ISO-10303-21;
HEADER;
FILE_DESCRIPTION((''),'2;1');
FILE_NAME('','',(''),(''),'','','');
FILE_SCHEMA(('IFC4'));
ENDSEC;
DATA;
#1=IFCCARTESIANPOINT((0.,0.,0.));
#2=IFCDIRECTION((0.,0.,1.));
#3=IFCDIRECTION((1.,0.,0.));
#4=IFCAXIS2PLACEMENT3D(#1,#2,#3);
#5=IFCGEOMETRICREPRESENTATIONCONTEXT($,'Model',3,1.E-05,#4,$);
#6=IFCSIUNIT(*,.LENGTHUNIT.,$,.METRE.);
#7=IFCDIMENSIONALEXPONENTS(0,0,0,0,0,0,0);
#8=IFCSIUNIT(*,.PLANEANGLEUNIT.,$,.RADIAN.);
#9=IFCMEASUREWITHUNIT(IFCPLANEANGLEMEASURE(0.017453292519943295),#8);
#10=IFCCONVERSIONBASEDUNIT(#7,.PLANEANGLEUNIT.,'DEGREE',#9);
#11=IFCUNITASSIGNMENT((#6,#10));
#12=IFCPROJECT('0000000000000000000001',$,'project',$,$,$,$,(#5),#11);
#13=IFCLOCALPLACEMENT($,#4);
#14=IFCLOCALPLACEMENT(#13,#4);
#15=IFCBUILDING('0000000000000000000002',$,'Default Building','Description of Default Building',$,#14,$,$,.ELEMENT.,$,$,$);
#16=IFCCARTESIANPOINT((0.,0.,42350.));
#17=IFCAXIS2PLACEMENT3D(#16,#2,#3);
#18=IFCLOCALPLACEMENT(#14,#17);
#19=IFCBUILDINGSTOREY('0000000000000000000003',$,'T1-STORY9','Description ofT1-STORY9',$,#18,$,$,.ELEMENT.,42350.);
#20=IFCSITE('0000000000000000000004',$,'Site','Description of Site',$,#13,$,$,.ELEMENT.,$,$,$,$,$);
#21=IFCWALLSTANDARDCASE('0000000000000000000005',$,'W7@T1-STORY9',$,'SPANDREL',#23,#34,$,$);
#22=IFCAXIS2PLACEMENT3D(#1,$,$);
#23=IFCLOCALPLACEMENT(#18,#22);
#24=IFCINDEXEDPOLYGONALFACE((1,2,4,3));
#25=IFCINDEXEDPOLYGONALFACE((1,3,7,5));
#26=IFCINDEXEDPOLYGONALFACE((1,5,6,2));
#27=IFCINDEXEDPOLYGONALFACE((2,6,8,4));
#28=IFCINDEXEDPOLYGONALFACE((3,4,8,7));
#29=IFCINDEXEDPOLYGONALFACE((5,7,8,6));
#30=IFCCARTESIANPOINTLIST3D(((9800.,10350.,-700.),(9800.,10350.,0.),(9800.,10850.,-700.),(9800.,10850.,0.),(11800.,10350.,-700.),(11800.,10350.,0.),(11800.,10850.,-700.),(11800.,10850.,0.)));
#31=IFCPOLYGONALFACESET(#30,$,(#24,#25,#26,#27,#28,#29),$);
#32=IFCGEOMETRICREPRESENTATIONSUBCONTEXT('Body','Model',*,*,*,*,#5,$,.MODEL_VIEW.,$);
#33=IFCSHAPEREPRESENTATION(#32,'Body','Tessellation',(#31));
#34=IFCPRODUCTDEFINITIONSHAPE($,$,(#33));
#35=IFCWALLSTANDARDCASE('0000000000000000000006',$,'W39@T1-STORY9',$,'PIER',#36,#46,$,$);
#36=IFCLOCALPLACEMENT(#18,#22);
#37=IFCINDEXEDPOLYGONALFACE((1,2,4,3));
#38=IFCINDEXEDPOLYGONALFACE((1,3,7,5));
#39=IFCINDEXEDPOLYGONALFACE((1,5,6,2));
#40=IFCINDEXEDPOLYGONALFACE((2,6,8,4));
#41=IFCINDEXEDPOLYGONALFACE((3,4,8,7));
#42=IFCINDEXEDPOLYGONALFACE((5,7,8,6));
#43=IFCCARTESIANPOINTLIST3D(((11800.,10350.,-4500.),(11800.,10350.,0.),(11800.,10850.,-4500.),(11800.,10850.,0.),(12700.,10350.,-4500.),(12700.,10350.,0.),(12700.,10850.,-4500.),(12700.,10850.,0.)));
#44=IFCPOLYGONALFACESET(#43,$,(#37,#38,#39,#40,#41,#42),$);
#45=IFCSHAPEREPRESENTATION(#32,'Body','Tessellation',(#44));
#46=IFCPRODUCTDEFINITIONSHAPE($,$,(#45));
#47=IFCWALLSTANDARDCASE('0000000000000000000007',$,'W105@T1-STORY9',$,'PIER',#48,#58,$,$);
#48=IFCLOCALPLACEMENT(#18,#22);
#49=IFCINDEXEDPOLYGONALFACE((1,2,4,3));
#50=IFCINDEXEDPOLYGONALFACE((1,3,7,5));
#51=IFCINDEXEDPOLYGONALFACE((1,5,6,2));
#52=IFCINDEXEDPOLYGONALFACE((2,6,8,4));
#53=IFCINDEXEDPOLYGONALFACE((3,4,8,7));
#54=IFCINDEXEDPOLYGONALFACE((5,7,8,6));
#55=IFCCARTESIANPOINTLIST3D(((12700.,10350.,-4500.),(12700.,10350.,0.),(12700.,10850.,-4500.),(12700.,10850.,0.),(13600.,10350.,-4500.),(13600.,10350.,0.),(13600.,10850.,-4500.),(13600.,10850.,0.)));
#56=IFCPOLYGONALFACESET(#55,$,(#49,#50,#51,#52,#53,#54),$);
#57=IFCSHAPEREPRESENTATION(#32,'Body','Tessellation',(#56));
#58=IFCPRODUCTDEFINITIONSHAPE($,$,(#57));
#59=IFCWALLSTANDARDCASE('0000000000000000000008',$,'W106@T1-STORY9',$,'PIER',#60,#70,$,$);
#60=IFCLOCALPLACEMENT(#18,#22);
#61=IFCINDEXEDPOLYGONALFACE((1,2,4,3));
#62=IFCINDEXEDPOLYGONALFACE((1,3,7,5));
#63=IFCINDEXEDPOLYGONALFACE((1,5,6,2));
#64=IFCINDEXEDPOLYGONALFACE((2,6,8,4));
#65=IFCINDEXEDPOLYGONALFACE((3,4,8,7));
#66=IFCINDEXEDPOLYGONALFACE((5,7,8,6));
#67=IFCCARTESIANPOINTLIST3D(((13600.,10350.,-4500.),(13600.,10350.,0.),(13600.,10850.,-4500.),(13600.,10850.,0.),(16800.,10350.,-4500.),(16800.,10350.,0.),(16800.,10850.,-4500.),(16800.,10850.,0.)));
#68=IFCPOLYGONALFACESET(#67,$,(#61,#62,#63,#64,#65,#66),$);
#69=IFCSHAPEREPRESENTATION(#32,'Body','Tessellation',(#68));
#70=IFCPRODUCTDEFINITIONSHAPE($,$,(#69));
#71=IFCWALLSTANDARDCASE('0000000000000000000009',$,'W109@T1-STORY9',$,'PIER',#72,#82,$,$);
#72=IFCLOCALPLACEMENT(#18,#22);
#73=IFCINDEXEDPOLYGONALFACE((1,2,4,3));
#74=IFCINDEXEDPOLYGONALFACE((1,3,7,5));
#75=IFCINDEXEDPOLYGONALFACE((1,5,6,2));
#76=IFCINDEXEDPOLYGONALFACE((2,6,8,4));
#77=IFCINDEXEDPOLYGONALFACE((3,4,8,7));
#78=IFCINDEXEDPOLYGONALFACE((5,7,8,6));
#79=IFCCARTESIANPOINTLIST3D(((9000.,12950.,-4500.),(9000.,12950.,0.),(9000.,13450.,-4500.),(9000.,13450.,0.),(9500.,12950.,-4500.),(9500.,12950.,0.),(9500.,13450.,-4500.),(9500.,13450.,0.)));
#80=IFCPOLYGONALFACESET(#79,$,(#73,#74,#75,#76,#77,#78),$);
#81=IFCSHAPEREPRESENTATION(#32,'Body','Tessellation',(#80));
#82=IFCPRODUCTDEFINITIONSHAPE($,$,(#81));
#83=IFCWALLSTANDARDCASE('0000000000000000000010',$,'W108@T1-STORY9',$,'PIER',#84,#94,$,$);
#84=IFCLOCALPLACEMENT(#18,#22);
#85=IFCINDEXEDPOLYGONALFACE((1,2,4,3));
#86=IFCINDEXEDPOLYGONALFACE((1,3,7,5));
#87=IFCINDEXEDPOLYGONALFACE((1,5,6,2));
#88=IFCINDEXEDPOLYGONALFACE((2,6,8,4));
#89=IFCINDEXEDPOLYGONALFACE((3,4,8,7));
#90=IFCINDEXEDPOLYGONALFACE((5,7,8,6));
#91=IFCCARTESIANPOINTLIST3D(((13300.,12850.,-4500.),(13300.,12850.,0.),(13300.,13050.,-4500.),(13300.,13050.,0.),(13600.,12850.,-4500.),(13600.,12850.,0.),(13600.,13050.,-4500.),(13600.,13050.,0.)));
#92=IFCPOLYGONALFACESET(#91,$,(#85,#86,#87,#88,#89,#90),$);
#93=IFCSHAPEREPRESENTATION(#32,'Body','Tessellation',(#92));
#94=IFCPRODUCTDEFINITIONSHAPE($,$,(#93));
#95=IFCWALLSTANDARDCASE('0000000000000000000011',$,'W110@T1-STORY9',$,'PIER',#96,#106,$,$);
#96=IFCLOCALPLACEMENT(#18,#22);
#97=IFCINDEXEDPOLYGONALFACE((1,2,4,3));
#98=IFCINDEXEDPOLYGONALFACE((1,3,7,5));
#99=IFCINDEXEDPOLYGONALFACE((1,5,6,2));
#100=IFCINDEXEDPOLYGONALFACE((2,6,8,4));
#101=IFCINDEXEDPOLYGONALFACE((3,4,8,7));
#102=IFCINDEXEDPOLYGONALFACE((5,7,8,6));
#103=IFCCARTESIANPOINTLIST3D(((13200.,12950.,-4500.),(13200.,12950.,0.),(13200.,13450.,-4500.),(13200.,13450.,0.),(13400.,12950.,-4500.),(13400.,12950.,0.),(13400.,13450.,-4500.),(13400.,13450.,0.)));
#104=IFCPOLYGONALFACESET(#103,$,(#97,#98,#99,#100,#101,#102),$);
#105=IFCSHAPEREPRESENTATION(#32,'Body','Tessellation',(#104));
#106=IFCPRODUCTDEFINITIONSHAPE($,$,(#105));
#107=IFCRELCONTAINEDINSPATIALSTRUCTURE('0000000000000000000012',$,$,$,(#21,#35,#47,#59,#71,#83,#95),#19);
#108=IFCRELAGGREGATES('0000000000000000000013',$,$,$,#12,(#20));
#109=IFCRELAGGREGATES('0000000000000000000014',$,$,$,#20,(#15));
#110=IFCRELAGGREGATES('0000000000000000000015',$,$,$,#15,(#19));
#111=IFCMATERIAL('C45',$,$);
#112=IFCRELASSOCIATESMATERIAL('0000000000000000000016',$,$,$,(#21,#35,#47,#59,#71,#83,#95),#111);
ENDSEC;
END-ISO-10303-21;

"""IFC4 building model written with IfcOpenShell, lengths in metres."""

from ifc_helpers import new_model, entity, si_unit, converted_unit, frame, origin_with_axes, place, context, subcontext, project, spatial, indexed_curve, outline, extrude, material, element, save


model = new_model("IFC4")

# Units and contexts
model_context = context("Model", 3, precision=1e-05, world=origin_with_axes())
body_context = subcontext(model_context, "Body", "Model", "MODEL_VIEW")
ifc_project = project(units=[si_unit("LENGTHUNIT", "METRE"), converted_unit("PLANEANGLEUNIT", "DEGREE", entity("IfcPlaneAngleMeasure", 0.017453292519943295), si_unit("PLANEANGLEUNIT", "RADIAN"), dimensions=[0, 0, 0, 0, 0, 0, 0])], contexts=[model_context])

# Site, building, storey
site_placement = place(None, origin_with_axes())
site = spatial("IfcSite", under=ifc_project, at=site_placement, Name="Site", Description="Description of Site", CompositionType="ELEMENT")
building_placement = place(site_placement, origin_with_axes())
building = spatial("IfcBuilding", under=site, at=building_placement, Name="Default Building", Description="Description of Default Building", CompositionType="ELEMENT")
storey_placement = place(building_placement, frame((0.0, 0.0, 42350.0), z_axis=(0.0, 0.0, 1.0), x_axis=(1.0, 0.0, 0.0)))
storey = spatial("IfcBuildingStorey", under=building, at=storey_placement, Name="T1-STORY9", Description="Description ofT1-STORY9", CompositionType="ELEMENT", Elevation=42350.0)

# Shared definitions
ifc_material_1 = material(Name="C45")

# Walls
wall_1_placement = place(storey_placement, frame((9800.0, 10600.0, -700.0), z_axis=(0.0, 0.0, 1.0), x_axis=(1.0, 0.0, 0.0)))
element("IfcWallStandardCase", 1, at=wall_1_placement, inside=storey, material=ifc_material_1, Name="W7@T1-STORY9", ObjectType="SPANDREL", context=body_context, shape_type="SweptSolid", body=[
    extrude(outline(indexed_curve([(0.0, -250.0), (0.0, 250.0), (2000.0, 250.0), (2000.0, -250.0), (0.0, -250.0)], self_intersect=False)), origin_with_axes(), (0.0, 0.0, 1.0), 700.0),
])
for number, where, z_axis, x_axis, name in (
    (2, (11800.0, 10600.0, -4500.0), (0.0, 0.0, 1.0), (1.0, 0.0, 0.0), "W39@T1-STORY9"),
    (3, (12700.0, 10600.0, -4500.0), (0.0, 0.0, 1.0), (1.0, 0.0, 0.0), "W105@T1-STORY9"),
):
    element("IfcWallStandardCase", number, at=place(storey_placement, frame(where, z_axis=z_axis, x_axis=x_axis)), inside=storey, material=ifc_material_1, Name=name, ObjectType="PIER", context=body_context, shape_type="SweptSolid", body=[
        extrude(outline(indexed_curve([(0.0, -250.0), (0.0, 250.0), (900.0, 250.0), (900.0, -250.0), (0.0, -250.0)], self_intersect=False)), origin_with_axes(), (0.0, 0.0, 1.0), 4500.0),
    ])
wall_2_placement = place(storey_placement, frame((13600.0, 10600.0, -4500.0), z_axis=(0.0, 0.0, 1.0), x_axis=(1.0, 0.0, 0.0)))
element("IfcWallStandardCase", 4, at=wall_2_placement, inside=storey, material=ifc_material_1, Name="W106@T1-STORY9", ObjectType="PIER", context=body_context, shape_type="SweptSolid", body=[
    extrude(outline(indexed_curve([(0.0, -250.0), (0.0, 250.0), (3200.0, 250.0), (3200.0, -250.0), (0.0, -250.0)], self_intersect=False)), origin_with_axes(), (0.0, 0.0, 1.0), 4500.0),
])
wall_3_placement = place(storey_placement, frame((9250.0, 12950.0, -4500.0), z_axis=(0.0, 0.0, 1.0), x_axis=(0.0, 1.0, 0.0)))
element("IfcWallStandardCase", 5, at=wall_3_placement, inside=storey, material=ifc_material_1, Name="W109@T1-STORY9", ObjectType="PIER", context=body_context, shape_type="SweptSolid", body=[
    extrude(outline(indexed_curve([(0.0, -250.0), (0.0, 250.0), (500.0, 250.0), (500.0, -250.0), (0.0, -250.0)], self_intersect=False)), origin_with_axes(), (0.0, 0.0, 1.0), 4500.0),
])
wall_4_placement = place(storey_placement, frame((13300.0, 12950.0, -4500.0), z_axis=(0.0, 0.0, 1.0), x_axis=(1.0, 0.0, 0.0)))
element("IfcWallStandardCase", 6, at=wall_4_placement, inside=storey, material=ifc_material_1, Name="W108@T1-STORY9", ObjectType="PIER", context=body_context, shape_type="SweptSolid", body=[
    extrude(outline(indexed_curve([(0.0, -100.0), (0.0, 100.0), (300.0, 100.0), (300.0, -100.0), (0.0, -100.0)], self_intersect=False)), origin_with_axes(), (0.0, 0.0, 1.0), 4500.0),
])
wall_5_placement = place(storey_placement, frame((13300.0, 12950.0, -4500.0), z_axis=(0.0, 0.0, 1.0), x_axis=(0.0, 1.0, 0.0)))
element("IfcWallStandardCase", 7, at=wall_5_placement, inside=storey, material=ifc_material_1, Name="W110@T1-STORY9", ObjectType="PIER", context=body_context, shape_type="SweptSolid", body=[
    extrude(outline(indexed_curve([(0.0, -100.0), (0.0, 100.0), (500.0, 100.0), (500.0, -100.0), (0.0, -100.0)], self_intersect=False)), origin_with_axes(), (0.0, 0.0, 1.0), 4500.0),
])

save(model, "model.ifc")
